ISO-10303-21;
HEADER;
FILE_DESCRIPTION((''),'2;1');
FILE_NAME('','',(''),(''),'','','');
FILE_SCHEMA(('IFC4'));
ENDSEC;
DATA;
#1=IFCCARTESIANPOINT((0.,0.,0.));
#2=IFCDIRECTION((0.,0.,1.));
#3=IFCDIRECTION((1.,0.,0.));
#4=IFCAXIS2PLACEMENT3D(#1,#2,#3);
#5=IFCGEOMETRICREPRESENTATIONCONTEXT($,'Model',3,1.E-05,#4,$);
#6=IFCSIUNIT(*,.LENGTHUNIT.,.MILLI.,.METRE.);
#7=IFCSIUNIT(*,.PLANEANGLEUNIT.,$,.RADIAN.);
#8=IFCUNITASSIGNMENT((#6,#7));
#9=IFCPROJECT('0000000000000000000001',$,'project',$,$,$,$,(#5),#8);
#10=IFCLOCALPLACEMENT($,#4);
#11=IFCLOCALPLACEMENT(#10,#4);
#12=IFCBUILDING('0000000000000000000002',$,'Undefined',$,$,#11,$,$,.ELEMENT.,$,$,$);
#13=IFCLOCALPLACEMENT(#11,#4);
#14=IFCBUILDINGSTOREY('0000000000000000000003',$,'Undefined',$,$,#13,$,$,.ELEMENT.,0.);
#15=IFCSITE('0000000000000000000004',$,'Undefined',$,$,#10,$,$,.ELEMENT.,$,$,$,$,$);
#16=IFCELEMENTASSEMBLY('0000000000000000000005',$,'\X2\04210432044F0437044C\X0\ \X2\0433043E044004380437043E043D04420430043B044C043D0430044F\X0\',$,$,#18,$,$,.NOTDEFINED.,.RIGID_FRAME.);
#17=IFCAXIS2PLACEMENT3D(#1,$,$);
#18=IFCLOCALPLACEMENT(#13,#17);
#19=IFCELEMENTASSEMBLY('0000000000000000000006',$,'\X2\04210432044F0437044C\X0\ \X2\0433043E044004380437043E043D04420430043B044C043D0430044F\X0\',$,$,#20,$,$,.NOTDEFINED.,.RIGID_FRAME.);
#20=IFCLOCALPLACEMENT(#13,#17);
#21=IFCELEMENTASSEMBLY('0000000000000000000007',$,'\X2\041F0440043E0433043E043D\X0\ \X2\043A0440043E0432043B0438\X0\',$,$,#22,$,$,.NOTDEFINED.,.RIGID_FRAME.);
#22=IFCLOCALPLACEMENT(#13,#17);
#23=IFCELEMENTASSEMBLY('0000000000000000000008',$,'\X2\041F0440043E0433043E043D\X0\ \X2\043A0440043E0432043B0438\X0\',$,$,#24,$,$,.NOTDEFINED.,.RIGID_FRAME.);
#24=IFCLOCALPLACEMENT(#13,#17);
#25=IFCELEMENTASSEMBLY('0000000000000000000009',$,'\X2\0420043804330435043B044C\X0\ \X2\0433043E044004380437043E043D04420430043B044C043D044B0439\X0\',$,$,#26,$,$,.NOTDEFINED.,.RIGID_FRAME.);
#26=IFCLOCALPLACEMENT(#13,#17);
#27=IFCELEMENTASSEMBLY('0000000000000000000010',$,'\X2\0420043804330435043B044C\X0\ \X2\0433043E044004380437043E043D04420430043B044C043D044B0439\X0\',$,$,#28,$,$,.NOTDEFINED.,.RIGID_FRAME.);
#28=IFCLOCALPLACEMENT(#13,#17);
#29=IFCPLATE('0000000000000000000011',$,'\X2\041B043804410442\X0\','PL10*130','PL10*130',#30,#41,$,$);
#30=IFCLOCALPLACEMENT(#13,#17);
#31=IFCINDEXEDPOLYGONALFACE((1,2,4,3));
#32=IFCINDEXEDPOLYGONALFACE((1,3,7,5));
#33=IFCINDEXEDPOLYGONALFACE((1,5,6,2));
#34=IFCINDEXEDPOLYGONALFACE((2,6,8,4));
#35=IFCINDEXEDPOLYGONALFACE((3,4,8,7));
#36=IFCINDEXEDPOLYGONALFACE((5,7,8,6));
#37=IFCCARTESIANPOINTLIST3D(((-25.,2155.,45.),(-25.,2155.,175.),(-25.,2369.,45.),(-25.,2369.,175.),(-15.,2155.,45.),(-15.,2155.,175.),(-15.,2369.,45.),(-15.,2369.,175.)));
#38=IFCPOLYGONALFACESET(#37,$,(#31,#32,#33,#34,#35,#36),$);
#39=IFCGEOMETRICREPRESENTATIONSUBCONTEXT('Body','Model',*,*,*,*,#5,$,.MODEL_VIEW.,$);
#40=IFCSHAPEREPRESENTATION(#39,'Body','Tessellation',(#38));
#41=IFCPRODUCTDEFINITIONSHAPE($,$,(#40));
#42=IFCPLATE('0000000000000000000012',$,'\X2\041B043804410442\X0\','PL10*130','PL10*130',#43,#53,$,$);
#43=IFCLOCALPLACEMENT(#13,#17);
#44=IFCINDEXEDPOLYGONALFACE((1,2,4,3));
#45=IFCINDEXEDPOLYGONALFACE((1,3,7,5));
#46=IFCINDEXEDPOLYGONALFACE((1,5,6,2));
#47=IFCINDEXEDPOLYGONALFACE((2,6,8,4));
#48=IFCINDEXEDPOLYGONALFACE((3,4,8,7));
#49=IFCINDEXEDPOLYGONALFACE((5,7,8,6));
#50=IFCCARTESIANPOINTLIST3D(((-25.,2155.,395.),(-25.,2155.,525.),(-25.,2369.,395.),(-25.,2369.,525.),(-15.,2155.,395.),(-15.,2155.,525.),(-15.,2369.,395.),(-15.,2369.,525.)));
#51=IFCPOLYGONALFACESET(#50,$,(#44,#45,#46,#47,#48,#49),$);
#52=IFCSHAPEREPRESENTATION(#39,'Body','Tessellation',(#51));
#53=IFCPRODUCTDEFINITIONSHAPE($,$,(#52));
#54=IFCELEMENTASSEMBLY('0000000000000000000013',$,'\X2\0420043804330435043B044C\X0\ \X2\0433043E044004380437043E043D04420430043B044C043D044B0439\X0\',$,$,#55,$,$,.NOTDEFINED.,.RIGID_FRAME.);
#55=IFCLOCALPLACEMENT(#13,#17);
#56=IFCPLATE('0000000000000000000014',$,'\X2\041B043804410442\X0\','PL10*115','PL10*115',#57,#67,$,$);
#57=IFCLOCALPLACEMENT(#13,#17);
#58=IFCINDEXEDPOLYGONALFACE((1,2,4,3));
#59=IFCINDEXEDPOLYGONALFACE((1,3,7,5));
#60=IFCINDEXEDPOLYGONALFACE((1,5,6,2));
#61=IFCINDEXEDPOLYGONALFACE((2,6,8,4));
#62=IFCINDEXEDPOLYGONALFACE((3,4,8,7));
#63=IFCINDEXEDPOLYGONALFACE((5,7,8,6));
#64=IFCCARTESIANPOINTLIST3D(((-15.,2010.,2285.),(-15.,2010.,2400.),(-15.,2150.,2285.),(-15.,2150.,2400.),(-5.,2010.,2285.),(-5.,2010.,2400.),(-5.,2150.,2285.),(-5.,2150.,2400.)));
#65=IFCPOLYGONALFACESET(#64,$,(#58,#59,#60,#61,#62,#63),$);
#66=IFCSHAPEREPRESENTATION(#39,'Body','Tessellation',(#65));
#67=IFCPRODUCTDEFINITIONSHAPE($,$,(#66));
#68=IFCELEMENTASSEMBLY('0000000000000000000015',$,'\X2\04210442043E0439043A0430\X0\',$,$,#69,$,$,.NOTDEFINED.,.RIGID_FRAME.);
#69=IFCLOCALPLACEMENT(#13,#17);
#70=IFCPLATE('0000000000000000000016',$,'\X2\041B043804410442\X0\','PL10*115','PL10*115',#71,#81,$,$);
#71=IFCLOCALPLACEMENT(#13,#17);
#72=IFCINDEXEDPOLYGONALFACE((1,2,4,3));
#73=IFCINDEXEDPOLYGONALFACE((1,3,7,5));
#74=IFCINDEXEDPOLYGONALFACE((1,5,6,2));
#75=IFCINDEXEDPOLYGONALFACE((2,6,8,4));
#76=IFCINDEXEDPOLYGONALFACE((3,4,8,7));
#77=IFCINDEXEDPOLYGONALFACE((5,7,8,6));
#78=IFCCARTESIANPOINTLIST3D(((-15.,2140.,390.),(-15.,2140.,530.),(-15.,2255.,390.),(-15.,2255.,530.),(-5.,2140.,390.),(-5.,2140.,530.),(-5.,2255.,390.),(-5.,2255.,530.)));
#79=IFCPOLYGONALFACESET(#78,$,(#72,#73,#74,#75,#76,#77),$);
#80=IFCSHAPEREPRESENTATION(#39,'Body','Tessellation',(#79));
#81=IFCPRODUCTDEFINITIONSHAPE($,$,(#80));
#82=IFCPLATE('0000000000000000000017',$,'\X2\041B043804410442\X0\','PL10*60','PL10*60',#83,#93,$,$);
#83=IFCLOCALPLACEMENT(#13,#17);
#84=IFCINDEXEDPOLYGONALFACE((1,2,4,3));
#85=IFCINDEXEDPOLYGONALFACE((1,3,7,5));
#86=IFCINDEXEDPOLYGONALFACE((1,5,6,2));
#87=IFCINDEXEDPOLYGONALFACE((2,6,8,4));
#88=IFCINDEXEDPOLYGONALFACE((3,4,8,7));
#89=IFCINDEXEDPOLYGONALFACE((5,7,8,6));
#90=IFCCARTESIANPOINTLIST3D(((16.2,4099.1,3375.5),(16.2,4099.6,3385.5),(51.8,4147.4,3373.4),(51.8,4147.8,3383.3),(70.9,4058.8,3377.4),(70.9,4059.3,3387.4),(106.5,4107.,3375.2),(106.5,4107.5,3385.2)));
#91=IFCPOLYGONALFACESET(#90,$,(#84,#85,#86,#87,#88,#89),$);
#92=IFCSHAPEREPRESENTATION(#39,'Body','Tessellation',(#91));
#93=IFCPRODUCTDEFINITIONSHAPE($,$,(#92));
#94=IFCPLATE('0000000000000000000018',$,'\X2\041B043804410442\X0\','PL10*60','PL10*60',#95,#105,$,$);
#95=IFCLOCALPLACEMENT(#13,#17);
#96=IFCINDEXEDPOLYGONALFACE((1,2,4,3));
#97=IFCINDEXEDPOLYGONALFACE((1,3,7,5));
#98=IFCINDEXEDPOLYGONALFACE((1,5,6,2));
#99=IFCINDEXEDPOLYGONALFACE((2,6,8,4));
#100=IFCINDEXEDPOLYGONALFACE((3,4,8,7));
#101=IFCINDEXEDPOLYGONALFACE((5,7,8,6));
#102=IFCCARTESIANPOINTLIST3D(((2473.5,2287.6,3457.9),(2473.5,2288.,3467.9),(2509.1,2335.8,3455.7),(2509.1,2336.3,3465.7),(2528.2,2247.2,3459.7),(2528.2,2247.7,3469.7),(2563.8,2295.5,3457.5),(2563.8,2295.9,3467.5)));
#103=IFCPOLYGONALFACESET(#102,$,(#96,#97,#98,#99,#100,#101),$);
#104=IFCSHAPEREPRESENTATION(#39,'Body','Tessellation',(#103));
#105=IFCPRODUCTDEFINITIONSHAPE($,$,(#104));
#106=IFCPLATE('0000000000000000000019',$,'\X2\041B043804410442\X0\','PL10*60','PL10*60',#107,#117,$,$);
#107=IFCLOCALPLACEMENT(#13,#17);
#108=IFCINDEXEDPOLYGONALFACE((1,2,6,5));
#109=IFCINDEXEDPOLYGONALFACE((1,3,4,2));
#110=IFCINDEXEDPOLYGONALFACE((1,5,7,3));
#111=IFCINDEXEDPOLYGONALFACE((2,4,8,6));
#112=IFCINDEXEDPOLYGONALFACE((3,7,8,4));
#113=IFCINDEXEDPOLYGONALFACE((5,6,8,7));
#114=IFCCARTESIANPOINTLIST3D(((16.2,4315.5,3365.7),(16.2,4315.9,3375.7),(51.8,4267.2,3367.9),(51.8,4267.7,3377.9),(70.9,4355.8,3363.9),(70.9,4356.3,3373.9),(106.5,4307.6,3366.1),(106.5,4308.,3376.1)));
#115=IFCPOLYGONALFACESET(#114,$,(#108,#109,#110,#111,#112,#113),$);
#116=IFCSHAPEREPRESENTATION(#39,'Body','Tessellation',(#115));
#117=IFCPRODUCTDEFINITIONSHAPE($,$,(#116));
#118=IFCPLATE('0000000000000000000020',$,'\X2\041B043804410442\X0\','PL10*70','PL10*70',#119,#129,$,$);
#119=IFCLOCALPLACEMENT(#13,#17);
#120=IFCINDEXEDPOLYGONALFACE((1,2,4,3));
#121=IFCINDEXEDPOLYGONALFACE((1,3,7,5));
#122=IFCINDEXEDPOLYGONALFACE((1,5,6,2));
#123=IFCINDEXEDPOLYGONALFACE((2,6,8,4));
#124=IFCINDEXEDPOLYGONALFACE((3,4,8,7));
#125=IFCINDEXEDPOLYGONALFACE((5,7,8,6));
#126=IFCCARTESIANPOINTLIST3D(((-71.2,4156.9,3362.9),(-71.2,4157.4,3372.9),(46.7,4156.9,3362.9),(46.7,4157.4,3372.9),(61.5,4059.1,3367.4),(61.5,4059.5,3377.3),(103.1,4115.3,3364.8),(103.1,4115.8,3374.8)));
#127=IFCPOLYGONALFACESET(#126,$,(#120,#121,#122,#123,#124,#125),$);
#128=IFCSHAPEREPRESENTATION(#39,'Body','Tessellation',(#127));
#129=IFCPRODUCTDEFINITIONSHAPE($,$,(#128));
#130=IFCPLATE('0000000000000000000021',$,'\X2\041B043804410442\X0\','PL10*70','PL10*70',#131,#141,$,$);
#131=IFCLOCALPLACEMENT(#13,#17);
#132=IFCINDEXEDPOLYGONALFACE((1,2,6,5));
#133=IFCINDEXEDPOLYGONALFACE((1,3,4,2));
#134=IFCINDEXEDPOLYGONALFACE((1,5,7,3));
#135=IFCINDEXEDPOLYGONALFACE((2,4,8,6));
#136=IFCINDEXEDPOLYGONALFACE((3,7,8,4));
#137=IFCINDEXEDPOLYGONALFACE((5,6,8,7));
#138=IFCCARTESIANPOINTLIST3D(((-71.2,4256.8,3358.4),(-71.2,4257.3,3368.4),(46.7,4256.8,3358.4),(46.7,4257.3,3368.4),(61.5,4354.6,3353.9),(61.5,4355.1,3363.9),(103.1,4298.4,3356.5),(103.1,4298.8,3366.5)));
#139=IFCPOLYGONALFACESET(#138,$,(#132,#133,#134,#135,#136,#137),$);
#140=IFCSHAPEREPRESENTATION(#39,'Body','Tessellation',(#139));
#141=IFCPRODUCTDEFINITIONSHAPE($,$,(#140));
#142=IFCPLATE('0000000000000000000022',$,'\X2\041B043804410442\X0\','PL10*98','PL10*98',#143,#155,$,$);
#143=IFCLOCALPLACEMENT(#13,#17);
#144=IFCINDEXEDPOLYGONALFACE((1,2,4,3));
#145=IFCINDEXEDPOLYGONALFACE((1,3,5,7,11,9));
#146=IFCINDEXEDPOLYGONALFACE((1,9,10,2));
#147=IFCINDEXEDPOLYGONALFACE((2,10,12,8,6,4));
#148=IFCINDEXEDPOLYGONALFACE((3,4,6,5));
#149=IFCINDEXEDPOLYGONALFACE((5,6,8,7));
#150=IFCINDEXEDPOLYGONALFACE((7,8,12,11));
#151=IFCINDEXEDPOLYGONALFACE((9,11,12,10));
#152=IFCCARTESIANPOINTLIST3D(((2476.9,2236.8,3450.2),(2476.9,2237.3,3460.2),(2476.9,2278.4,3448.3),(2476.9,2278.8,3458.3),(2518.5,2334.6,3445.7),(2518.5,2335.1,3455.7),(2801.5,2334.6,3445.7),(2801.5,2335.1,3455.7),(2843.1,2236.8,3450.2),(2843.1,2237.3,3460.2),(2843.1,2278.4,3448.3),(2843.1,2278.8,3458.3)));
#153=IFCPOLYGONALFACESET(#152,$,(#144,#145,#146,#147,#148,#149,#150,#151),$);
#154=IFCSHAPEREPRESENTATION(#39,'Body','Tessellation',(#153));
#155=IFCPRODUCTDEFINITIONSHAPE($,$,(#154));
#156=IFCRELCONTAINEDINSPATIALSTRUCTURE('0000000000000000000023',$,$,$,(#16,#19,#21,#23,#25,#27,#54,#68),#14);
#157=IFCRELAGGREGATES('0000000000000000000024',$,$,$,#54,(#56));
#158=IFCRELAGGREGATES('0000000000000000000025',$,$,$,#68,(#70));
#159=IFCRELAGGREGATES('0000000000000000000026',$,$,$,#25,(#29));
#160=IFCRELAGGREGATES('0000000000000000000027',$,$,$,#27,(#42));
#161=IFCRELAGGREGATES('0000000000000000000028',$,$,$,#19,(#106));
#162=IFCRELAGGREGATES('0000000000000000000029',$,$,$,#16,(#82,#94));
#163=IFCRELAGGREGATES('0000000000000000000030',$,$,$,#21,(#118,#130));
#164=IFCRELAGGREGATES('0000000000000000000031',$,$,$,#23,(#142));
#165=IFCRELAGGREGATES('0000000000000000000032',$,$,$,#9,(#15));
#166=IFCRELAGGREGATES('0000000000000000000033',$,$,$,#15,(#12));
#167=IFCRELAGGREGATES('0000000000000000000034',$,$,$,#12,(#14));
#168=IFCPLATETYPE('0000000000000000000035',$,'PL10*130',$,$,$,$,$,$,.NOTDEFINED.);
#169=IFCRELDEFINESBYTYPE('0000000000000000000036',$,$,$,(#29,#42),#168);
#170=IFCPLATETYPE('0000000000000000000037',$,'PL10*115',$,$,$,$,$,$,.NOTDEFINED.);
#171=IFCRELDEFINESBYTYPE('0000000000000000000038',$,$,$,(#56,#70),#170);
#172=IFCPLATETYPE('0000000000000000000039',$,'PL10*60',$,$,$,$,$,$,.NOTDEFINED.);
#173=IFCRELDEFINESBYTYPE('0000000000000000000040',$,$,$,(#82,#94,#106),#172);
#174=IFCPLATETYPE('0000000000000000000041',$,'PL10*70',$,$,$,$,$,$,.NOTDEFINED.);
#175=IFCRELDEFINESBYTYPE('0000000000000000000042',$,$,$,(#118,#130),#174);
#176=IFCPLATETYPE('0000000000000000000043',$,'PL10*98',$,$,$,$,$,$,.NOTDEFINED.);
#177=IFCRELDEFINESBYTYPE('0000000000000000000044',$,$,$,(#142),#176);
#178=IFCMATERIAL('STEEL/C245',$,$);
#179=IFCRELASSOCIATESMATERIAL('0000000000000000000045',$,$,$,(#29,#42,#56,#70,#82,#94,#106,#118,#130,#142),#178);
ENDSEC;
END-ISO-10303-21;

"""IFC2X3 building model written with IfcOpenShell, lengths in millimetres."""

from ifc_helpers import new_model, si_unit, frame, origin_with_axes, place, context, subcontext, project, spatial, polyline, outline, extrude, material, type_object, element, aggregate, save


model = new_model("IFC2X3")

# Units and contexts
model_context = context("Model", 3, precision=1e-05, world=origin_with_axes())
body_context = subcontext(model_context, "Body", "Model", "MODEL_VIEW")
ifc_project = project(units=[si_unit("LENGTHUNIT", "METRE", prefix="MILLI"), si_unit("PLANEANGLEUNIT", "RADIAN")], contexts=[model_context])

# Site, building, storey
site_placement = place(None, origin_with_axes())
site = spatial("IfcSite", under=ifc_project, at=site_placement, Name="Undefined", CompositionType="ELEMENT")
building_placement = place(site_placement, origin_with_axes())
building = spatial("IfcBuilding", under=site, at=building_placement, Name="Undefined", CompositionType="ELEMENT")
storey_placement = place(building_placement, origin_with_axes())
storey = spatial("IfcBuildingStorey", under=building, at=storey_placement, Name="Undefined", CompositionType="ELEMENT", Elevation=0.0)

# Element assemblies
assembly_1_placement = place(storey_placement, origin_with_axes())
assembly_1 = element("IfcElementAssembly", 1, at=assembly_1_placement, inside=storey, Name="Связь горизонтальная", AssemblyPlace="NOTDEFINED", PredefinedType="RIGID_FRAME")
ifc_material_1 = material(Name="STEEL/C245")
assembly_2_placement = place(storey_placement, origin_with_axes())
assembly_2 = element("IfcElementAssembly", 2, at=assembly_2_placement, inside=storey, Name="Связь горизонтальная", AssemblyPlace="NOTDEFINED", PredefinedType="RIGID_FRAME")

# Element assemblies
assembly_3_placement = place(storey_placement, origin_with_axes())
assembly_3 = element("IfcElementAssembly", 3, at=assembly_3_placement, inside=storey, Name="Прогон кровли", AssemblyPlace="NOTDEFINED", PredefinedType="RIGID_FRAME")
assembly_4_placement = place(storey_placement, origin_with_axes())
assembly_4 = element("IfcElementAssembly", 4, at=assembly_4_placement, inside=storey, Name="Прогон кровли", AssemblyPlace="NOTDEFINED", PredefinedType="RIGID_FRAME")

# Element assemblies
assembly_5_placement = place(storey_placement, origin_with_axes())
assembly_5 = element("IfcElementAssembly", 5, at=assembly_5_placement, inside=storey, Name="Ригель горизонтальный", AssemblyPlace="NOTDEFINED", PredefinedType="RIGID_FRAME")
assembly_6_placement = place(storey_placement, origin_with_axes())
assembly_6 = element("IfcElementAssembly", 6, at=assembly_6_placement, inside=storey, Name="Ригель горизонтальный", AssemblyPlace="NOTDEFINED", PredefinedType="RIGID_FRAME")

# Plates
plate_type_1 = type_object("IfcPlateType", Name="PL10*130", PredefinedType="NOTDEFINED")
plate_1_placement = place(assembly_5_placement, frame((-20.0, 2155.0, 110.0), z_axis=(-1.0, 0.0, 0.0), x_axis=(0.0, 1.0, 0.0)))
plate_1 = element("IfcPlate", 7, at=plate_1_placement, type_object=plate_type_1, material=ifc_material_1, Name="Лист", Description="PL10*130", ObjectType="PL10*130", context=body_context, shape_type="SweptSolid", body=[
    extrude(outline(polyline([(0.0, 65.0), (214.0, 65.0), (214.0, -65.0), (0.0, -65.0), (0.0, 65.0)])), frame((0.0, 0.0, -5.0), z_axis=(0.0, 0.0, 1.0), x_axis=(1.0, 0.0, 0.0)), (0.0, 0.0, 1.0), 10.0),
])
plate_2_placement = place(assembly_6_placement, frame((-20.0, 2155.0, 460.0), z_axis=(-1.0, 0.0, 0.0), x_axis=(0.0, 1.0, 0.0)))
plate_2 = element("IfcPlate", 8, at=plate_2_placement, type_object=plate_type_1, material=ifc_material_1, Name="Лист", Description="PL10*130", ObjectType="PL10*130", context=body_context, shape_type="SweptSolid", body=[
    extrude(outline(polyline([(0.0, 65.0), (214.0, 65.0), (214.0, -65.0), (0.0, -65.0), (0.0, 65.0)])), frame((0.0, 0.0, -5.0), z_axis=(0.0, 0.0, 1.0), x_axis=(1.0, 0.0, 0.0)), (0.0, 0.0, 1.0), 10.0),
])

# Element assemblies, plates
assembly_7_placement = place(storey_placement, origin_with_axes())
assembly_7 = element("IfcElementAssembly", 9, at=assembly_7_placement, inside=storey, Name="Ригель горизонтальный", AssemblyPlace="NOTDEFINED", PredefinedType="RIGID_FRAME")
plate_type_2 = type_object("IfcPlateType", Name="PL10*115", PredefinedType="NOTDEFINED")
plate_3_placement = place(assembly_7_placement, frame((-10.0, 2150.0, 2400.0), z_axis=(-1.0, 0.0, 0.0), x_axis=(0.0, 0.0, -1.0)))
plate_3 = element("IfcPlate", 10, at=plate_3_placement, type_object=plate_type_2, material=ifc_material_1, Name="Лист", Description="PL10*115", ObjectType="PL10*115", context=body_context, shape_type="SweptSolid", body=[
    extrude(outline(polyline([(0.0, 0.0), (115.0, 0.0), (115.0, 140.0), (0.0, 140.0), (0.0, 0.0)])), frame((0.0, 0.0, -5.0), z_axis=(0.0, 0.0, 1.0), x_axis=(1.0, 0.0, 0.0)), (0.0, 0.0, 1.0), 10.0),
])
aggregate(assembly_7, [plate_3])
assembly_8_placement = place(storey_placement, origin_with_axes())
assembly_8 = element("IfcElementAssembly", 11, at=assembly_8_placement, inside=storey, Name="Стойка", AssemblyPlace="NOTDEFINED", PredefinedType="RIGID_FRAME")
plate_4_placement = place(assembly_8_placement, frame((-10.0, 2140.0, 530.0), z_axis=(-1.0, 0.0, 0.0), x_axis=(0.0, 1.0, 0.0)))
plate_4 = element("IfcPlate", 12, at=plate_4_placement, type_object=plate_type_2, material=ifc_material_1, Name="Лист", Description="PL10*115", ObjectType="PL10*115", context=body_context, shape_type="SweptSolid", body=[
    extrude(outline(polyline([(0.0, 0.0), (115.0, 0.0), (115.0, 140.0), (0.0, 140.0), (0.0, 0.0)])), frame((0.0, 0.0, -5.0), z_axis=(0.0, 0.0, 1.0), x_axis=(1.0, 0.0, 0.0)), (0.0, 0.0, 1.0), 10.0),
])
aggregate(assembly_8, [plate_4])

# Plates
plate_type_3 = type_object("IfcPlateType", Name="PL10*60", PredefinedType="NOTDEFINED")
plate_5_placement = place(assembly_1_placement, frame((34.0, 4123.5, 3379.4), z_axis=(0.0, 0.045408, 0.998969), x_axis=(0.804616, -0.593183, 0.026963)))
plate_5 = element("IfcPlate", 13, at=plate_5_placement, type_object=plate_type_3, material=ifc_material_1, Name="Лист", Description="PL10*60", ObjectType="PL10*60", context=body_context, shape_type="SweptSolid", body=[
    extrude(outline(polyline([(0.0, -30.0), (0.0, 30.0), (68.0, 30.0), (68.0, -30.0), (0.0, -30.0)])), frame((0.0, 0.0, -5.0), z_axis=(0.0, 0.0, 1.0), x_axis=(1.0, 0.0, 0.0)), (0.0, 0.0, 1.0), 10.0),
])
plate_6_placement = place(assembly_1_placement, frame((2546.0, 2271.6, 3463.6), z_axis=(0.0, -0.045408, -0.998969), x_axis=(-0.804616, 0.593183, -0.026963)))
plate_6 = element("IfcPlate", 14, at=plate_6_placement, type_object=plate_type_3, material=ifc_material_1, Name="Лист", Description="PL10*60", ObjectType="PL10*60", context=body_context, shape_type="SweptSolid", body=[
    extrude(outline(polyline([(68.0, -30.0), (0.0, -30.0), (0.0, 30.0), (68.0, 30.0), (68.0, -30.0)])), frame((0.0, 0.0, -5.0), z_axis=(0.0, 0.0, 1.0), x_axis=(1.0, 0.0, 0.0)), (0.0, 0.0, 1.0), 10.0),
])
plate_7_placement = place(assembly_2_placement, frame((34.0, 4291.6, 3371.8), z_axis=(0.0, -0.045408, -0.998969), x_axis=(0.804616, 0.593183, -0.026963)))
plate_7 = element("IfcPlate", 15, at=plate_7_placement, type_object=plate_type_3, material=ifc_material_1, Name="Лист", Description="PL10*60", ObjectType="PL10*60", context=body_context, shape_type="SweptSolid", body=[
    extrude(outline(polyline([(0.0, -30.0), (0.0, 30.0), (68.0, 30.0), (68.0, -30.0), (0.0, -30.0)])), frame((0.0, 0.0, -5.0), z_axis=(0.0, 0.0, 1.0), x_axis=(1.0, 0.0, 0.0)), (0.0, 0.0, 1.0), 10.0),
])
plate_type_4 = type_object("IfcPlateType", Name="PL10*70", PredefinedType="NOTDEFINED")
plate_8_placement = place(assembly_3_placement, frame((-71.2, 4157.1, 3367.9), z_axis=(0.0, 0.045408, 0.998969), x_axis=(0.804616, -0.593183, 0.026963)))
plate_8 = element("IfcPlate", 16, at=plate_8_placement, type_object=plate_type_4, material=ifc_material_1, Name="Лист", Description="PL10*70", ObjectType="PL10*70", context=body_context, shape_type="SweptSolid", body=[
    extrude(outline(polyline([(0.0, 0.0), (164.9, 0.0), (164.9, 70.0), (94.9, 70.0), (0.0, 0.0)])), frame((0.0, 0.0, -5.0), z_axis=(0.0, 0.0, 1.0), x_axis=(1.0, 0.0, 0.0)), (0.0, 0.0, 1.0), 10.0),
])
plate_9_placement = place(assembly_3_placement, frame((-71.2, 4257.0, 3363.4), z_axis=(0.0, -0.045408, -0.998969), x_axis=(0.804616, 0.593183, -0.026963)))
plate_9 = element("IfcPlate", 17, at=plate_9_placement, type_object=plate_type_4, material=ifc_material_1, Name="Лист", Description="PL10*70", ObjectType="PL10*70", context=body_context, shape_type="SweptSolid", body=[
    extrude(outline(polyline([(0.0, 0.0), (164.9, 0.0), (164.9, 70.0), (94.9, 70.0), (0.0, 0.0)])), frame((0.0, 0.0, -5.0), z_axis=(0.0, 0.0, 1.0), x_axis=(1.0, 0.0, 0.0)), (0.0, 0.0, 1.0), 10.0),
])
plate_type_5 = type_object("IfcPlateType", Name="PL10*98", PredefinedType="NOTDEFINED")
plate_10_placement = place(assembly_4_placement, frame((2476.9, 2237.0, 3455.2), z_axis=(0.0, -0.045408, -0.998969), x_axis=(0.0, 0.998969, -0.045408)))
plate_10 = element("IfcPlate", 18, at=plate_10_placement, type_object=plate_type_5, material=ifc_material_1, Name="Лист", Description="PL10*98", ObjectType="PL10*98", context=body_context, shape_type="SweptSolid", body=[
    extrude(outline(polyline([(0.0, 0.0), (41.6, 0.0), (97.9, 41.6), (97.9, 324.6), (41.6, 366.1), (0.0, 366.1), (0.0, 0.0)])), frame((0.0, 0.0, -5.0), z_axis=(0.0, 0.0, 1.0), x_axis=(1.0, 0.0, 0.0)), (0.0, 0.0, 1.0), 10.0),
])

aggregate(assembly_5, [plate_1])
aggregate(assembly_6, [plate_2])
aggregate(assembly_2, [plate_7])
aggregate(assembly_1, [plate_5, plate_6])
aggregate(assembly_3, [plate_8, plate_9])
aggregate(assembly_4, [plate_10])

save(model, "model.ifc")
